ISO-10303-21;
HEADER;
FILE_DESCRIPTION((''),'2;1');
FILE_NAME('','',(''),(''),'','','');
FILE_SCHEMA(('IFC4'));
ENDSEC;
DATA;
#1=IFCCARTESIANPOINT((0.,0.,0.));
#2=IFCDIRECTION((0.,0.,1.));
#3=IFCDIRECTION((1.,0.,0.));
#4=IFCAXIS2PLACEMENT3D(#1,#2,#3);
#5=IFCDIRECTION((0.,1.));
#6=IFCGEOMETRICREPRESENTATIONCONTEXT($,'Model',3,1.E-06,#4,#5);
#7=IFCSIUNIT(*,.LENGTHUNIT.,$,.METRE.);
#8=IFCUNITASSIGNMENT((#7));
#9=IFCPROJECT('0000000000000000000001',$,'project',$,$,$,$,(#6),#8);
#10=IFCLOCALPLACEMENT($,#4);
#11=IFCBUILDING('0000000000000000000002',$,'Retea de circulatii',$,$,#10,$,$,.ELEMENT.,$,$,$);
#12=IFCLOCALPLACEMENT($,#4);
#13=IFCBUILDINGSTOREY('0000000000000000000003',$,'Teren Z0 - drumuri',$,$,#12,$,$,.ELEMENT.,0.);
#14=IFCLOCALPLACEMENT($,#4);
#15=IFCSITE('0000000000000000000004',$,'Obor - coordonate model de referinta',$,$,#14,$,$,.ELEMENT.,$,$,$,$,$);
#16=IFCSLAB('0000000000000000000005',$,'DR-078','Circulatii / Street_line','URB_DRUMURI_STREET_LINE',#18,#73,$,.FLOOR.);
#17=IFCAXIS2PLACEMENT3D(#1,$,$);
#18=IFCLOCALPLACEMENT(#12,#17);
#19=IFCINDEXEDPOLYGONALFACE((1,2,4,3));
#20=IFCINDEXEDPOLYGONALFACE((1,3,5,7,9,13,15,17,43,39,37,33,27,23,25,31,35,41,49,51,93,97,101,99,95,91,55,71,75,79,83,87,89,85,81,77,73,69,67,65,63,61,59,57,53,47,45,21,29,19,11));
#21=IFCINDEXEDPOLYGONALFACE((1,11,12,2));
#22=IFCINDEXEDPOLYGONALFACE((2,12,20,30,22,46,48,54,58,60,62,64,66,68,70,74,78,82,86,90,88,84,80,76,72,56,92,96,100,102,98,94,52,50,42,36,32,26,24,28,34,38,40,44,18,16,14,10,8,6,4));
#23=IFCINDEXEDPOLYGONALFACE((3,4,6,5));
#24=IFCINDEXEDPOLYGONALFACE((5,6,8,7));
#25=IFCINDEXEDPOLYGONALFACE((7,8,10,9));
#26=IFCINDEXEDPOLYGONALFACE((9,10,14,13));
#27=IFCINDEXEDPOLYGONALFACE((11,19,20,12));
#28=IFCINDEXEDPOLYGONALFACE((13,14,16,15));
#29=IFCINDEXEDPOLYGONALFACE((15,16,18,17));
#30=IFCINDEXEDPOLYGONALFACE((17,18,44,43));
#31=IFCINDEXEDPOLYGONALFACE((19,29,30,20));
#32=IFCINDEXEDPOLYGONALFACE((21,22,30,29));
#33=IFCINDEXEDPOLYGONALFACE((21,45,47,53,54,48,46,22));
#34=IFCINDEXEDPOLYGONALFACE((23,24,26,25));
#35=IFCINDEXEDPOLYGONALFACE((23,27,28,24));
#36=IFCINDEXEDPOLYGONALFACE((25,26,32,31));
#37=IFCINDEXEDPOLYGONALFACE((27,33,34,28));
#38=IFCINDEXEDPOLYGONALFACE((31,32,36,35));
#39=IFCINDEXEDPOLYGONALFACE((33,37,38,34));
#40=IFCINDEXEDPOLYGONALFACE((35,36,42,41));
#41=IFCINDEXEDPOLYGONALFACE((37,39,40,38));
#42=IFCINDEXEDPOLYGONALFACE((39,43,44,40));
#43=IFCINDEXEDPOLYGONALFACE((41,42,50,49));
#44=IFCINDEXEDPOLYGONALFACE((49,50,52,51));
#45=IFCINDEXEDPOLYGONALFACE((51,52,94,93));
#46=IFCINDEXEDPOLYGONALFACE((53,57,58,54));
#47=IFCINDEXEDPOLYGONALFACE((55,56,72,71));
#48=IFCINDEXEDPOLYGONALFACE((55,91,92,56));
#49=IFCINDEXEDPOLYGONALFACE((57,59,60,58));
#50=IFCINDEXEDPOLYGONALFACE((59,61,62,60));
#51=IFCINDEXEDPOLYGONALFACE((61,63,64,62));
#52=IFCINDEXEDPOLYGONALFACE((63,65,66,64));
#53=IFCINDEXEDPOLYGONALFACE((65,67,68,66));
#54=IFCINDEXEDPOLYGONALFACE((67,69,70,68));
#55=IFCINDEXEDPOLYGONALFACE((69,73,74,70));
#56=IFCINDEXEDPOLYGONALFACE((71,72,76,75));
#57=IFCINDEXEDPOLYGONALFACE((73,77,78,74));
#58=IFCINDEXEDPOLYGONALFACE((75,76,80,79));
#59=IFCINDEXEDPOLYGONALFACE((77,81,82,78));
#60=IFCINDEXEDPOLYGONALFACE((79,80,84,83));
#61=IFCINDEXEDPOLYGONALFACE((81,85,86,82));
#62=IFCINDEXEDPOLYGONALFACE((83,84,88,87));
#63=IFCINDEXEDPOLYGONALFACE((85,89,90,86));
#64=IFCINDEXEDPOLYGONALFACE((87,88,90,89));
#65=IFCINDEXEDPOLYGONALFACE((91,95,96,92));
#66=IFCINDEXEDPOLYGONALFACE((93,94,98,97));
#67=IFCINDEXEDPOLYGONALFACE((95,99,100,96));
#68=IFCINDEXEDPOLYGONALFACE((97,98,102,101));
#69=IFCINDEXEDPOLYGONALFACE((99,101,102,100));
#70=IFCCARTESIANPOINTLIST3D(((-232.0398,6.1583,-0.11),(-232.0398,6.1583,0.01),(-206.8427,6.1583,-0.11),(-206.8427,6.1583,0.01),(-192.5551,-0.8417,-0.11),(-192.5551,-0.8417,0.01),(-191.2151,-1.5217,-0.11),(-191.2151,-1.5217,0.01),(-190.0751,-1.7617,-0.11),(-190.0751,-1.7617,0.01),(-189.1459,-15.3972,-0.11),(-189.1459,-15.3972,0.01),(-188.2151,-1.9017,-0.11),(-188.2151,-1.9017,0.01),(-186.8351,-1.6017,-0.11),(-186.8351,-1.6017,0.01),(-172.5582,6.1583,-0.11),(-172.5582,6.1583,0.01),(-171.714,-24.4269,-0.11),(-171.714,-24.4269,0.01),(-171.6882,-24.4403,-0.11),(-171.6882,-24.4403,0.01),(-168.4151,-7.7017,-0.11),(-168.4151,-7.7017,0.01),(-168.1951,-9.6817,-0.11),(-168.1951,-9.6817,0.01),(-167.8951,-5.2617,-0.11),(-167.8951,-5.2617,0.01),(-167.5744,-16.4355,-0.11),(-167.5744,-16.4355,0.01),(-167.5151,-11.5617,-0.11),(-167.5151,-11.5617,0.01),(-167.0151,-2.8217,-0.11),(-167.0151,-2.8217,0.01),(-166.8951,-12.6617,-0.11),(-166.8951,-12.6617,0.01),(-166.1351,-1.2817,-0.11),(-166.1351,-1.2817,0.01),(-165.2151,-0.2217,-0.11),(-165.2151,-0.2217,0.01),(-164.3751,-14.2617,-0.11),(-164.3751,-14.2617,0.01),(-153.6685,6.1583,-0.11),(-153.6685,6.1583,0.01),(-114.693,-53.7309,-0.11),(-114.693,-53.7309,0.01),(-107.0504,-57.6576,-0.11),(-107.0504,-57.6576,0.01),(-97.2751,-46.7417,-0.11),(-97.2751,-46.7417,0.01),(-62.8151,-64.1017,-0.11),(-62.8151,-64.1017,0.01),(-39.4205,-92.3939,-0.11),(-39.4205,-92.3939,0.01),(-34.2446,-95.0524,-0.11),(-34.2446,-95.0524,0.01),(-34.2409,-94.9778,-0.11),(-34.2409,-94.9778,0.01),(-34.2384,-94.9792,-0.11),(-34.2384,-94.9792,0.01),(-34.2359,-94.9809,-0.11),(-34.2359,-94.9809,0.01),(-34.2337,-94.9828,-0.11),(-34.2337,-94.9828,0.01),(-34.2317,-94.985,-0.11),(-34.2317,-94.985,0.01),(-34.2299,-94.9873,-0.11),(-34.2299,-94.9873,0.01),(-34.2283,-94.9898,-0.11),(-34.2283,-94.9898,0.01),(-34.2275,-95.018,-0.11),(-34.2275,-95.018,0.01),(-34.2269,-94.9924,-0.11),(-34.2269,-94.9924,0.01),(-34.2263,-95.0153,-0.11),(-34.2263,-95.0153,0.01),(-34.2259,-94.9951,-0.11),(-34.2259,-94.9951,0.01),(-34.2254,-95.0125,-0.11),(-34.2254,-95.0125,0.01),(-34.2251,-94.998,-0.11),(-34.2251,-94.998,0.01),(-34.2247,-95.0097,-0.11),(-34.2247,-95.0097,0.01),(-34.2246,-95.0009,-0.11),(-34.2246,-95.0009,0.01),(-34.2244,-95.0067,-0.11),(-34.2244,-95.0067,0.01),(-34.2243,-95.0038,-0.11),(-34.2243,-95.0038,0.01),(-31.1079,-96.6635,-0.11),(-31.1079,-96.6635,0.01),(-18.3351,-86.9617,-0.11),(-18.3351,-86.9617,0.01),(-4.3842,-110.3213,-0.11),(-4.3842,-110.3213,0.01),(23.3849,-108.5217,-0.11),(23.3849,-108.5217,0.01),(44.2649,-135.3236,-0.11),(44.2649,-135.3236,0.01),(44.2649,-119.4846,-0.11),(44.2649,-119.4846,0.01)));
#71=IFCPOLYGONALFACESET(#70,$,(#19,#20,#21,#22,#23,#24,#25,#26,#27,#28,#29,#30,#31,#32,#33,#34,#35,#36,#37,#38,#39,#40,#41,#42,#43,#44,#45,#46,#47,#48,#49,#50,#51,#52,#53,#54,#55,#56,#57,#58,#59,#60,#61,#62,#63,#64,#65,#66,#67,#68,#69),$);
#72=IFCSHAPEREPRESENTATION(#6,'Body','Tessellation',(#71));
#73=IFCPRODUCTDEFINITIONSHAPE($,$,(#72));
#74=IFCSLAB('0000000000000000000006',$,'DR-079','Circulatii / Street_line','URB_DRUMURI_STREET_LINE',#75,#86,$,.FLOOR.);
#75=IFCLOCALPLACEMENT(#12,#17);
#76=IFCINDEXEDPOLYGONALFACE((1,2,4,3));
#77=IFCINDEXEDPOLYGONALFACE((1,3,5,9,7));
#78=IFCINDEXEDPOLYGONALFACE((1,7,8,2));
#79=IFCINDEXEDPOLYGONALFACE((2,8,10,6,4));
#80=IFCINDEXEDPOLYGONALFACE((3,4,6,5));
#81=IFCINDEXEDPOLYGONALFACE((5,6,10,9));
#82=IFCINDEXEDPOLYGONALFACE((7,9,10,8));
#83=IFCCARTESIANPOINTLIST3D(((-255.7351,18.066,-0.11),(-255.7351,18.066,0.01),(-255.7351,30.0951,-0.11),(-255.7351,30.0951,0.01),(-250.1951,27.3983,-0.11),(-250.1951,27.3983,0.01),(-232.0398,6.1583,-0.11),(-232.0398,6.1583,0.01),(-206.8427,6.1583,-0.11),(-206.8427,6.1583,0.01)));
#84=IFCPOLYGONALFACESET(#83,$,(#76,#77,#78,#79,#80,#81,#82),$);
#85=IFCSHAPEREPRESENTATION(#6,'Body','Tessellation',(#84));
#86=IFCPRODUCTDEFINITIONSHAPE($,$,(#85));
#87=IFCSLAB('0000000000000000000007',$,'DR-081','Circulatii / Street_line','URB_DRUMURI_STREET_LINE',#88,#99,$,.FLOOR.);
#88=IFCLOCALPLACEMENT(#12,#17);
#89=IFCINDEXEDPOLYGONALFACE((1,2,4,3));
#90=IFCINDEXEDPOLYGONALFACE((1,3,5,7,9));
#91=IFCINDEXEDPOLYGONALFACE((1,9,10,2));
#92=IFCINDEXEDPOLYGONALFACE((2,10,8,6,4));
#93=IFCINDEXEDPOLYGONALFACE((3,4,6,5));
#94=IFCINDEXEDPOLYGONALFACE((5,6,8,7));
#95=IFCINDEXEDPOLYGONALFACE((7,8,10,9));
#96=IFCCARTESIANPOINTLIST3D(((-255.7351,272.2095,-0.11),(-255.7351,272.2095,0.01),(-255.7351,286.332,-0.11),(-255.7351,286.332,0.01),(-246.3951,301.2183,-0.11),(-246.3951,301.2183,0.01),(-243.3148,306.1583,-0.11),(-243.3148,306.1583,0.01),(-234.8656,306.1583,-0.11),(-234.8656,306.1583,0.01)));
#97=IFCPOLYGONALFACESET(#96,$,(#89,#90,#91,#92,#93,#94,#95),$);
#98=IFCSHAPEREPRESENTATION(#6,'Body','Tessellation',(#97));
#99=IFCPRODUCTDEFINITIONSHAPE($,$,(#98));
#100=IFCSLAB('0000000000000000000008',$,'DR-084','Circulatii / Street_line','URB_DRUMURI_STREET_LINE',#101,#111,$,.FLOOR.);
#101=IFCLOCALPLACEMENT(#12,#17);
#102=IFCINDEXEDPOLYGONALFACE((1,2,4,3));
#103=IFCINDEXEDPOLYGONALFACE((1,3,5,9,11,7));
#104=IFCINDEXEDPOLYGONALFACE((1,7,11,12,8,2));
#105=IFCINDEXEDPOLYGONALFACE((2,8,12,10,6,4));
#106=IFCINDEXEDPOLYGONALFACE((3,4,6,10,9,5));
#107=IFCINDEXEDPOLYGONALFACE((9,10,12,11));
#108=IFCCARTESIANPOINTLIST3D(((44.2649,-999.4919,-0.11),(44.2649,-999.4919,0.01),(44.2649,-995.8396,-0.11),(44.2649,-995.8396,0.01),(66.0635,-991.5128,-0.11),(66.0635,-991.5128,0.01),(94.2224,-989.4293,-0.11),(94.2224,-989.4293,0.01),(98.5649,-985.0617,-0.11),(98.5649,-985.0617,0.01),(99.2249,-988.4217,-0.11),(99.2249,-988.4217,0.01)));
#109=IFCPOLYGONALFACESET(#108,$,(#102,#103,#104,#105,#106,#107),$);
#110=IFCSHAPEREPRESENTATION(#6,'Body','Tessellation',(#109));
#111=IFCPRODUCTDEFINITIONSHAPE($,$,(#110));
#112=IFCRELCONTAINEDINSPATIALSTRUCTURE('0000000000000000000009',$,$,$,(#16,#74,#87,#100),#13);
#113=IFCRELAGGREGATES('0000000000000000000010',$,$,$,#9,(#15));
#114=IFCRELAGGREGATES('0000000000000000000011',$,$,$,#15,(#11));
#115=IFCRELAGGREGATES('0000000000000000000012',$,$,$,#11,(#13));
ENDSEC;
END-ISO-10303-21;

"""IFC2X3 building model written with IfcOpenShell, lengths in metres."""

from ifc_helpers import new_model, si_unit, direction, frame, origin_with_axes, place, context, project, spatial, polyline, outline, extrude, element, save


model = new_model("IFC2X3")

# Units and contexts
model_context = context("Model", 3, precision=1e-06, world=origin_with_axes(), true_north=direction((0.0, 1.0)))
ifc_project = project(units=[si_unit("LENGTHUNIT", "METRE")], contexts=[model_context])

# Site, building, storey
site_placement = place(None, origin_with_axes())
site = spatial("IfcSite", under=ifc_project, at=site_placement, Name="Obor - coordonate model de referinta", CompositionType="ELEMENT")
building_placement = place(None, origin_with_axes())
building = spatial("IfcBuilding", under=site, at=building_placement, Name="Retea de circulatii", CompositionType="ELEMENT")
storey_placement = place(None, origin_with_axes())
storey = spatial("IfcBuildingStorey", under=building, at=storey_placement, Name="Teren Z0 - drumuri", CompositionType="ELEMENT", Elevation=0.0)

# Slabs
slab_1_placement = place(None, origin_with_axes())
element("IfcSlab", 1, at=slab_1_placement, inside=storey, Name="DR-078", Description="Circulatii / Street_line", ObjectType="URB_DRUMURI_STREET_LINE", PredefinedType="FLOOR", context=model_context, shape_type="SweptSolid", body=[
    extrude(outline(polyline([(-31.1079, -96.6635), (-4.3842, -110.3213), (44.2649, -135.3236), (44.2649, -119.4846), (23.3849, -108.5217), (-18.3351, -86.9617), (-62.8151, -64.1017), (-97.2751, -46.7417), (-164.3751, -14.2617), (-166.8951, -12.6617), (-167.5151, -11.5617), (-168.1951, -9.6817), (-168.4151, -7.7017), (-167.8951, -5.2617), (-167.0151, -2.8217), (-166.1351, -1.2817), (-165.2151, -0.2217), (-153.6685, 6.1583), (-172.5582, 6.1583), (-186.8351, -1.6017), (-186.8351, -1.6017), (-188.2151, -1.9017), (-190.0751, -1.7617), (-191.2151, -1.5217), (-192.5551, -0.8417), (-206.8427, 6.1583), (-232.0398, 6.1583), (-189.1459, -15.3972), (-171.714, -24.4269), (-167.5744, -16.4355), (-171.6882, -24.4403), (-114.693, -53.7309), (-107.0504, -57.6576), (-39.4205, -92.3939), (-34.2409, -94.9778), (-34.2384, -94.9792), (-34.2359, -94.9809), (-34.2337, -94.9828), (-34.2317, -94.985), (-34.2299, -94.9873), (-34.2283, -94.9898), (-34.2269, -94.9924), (-34.2259, -94.9951), (-34.2251, -94.998), (-34.2246, -95.0009), (-34.2243, -95.0038), (-34.2244, -95.0067), (-34.2247, -95.0097), (-34.2254, -95.0125), (-34.2263, -95.0153), (-34.2275, -95.018), (-34.2446, -95.0524), (-31.1079, -96.6635)])), frame((0.0, 0.0, -0.11), z_axis=(0.0, 0.0, 1.0), x_axis=(1.0, 0.0, 0.0)), (0.0, 0.0, 1.0), 0.12),
])
slab_2_placement = place(None, origin_with_axes())
element("IfcSlab", 2, at=slab_2_placement, inside=storey, Name="DR-079", Description="Circulatii / Street_line", ObjectType="URB_DRUMURI_STREET_LINE", PredefinedType="FLOOR", context=model_context, shape_type="SweptSolid", body=[
    extrude(outline(polyline([(-255.7351, 30.0951), (-255.7351, 18.066), (-232.0398, 6.1583), (-206.8427, 6.1583), (-250.1951, 27.3983), (-255.7351, 30.0951)])), frame((0.0, 0.0, -0.11), z_axis=(0.0, 0.0, 1.0), x_axis=(1.0, 0.0, 0.0)), (0.0, 0.0, 1.0), 0.12),
])
slab_3_placement = place(None, origin_with_axes())
element("IfcSlab", 3, at=slab_3_placement, inside=storey, Name="DR-081", Description="Circulatii / Street_line", ObjectType="URB_DRUMURI_STREET_LINE", PredefinedType="FLOOR", context=model_context, shape_type="SweptSolid", body=[
    extrude(outline(polyline([(-246.3951, 301.2183), (-255.7351, 286.332), (-255.7351, 272.2095), (-234.8656, 306.1583), (-243.3148, 306.1583), (-246.3951, 301.2183)])), frame((0.0, 0.0, -0.11), z_axis=(0.0, 0.0, 1.0), x_axis=(1.0, 0.0, 0.0)), (0.0, 0.0, 1.0), 0.12),
])
slab_4_placement = place(None, origin_with_axes())
element("IfcSlab", 4, at=slab_4_placement, inside=storey, Name="DR-084", Description="Circulatii / Street_line", ObjectType="URB_DRUMURI_STREET_LINE", PredefinedType="FLOOR", context=model_context, shape_type="SweptSolid", body=[
    extrude(outline(polyline([(98.5649, -985.0617), (66.0635, -991.5128), (44.2649, -995.8396), (44.2649, -999.4919), (94.2224, -989.4293), (99.2249, -988.4217), (98.5649, -985.0617)])), frame((0.0, 0.0, -0.11), z_axis=(0.0, 0.0, 1.0), x_axis=(1.0, 0.0, 0.0)), (0.0, 0.0, 1.0), 0.12),
])

save(model, "model.ifc")
